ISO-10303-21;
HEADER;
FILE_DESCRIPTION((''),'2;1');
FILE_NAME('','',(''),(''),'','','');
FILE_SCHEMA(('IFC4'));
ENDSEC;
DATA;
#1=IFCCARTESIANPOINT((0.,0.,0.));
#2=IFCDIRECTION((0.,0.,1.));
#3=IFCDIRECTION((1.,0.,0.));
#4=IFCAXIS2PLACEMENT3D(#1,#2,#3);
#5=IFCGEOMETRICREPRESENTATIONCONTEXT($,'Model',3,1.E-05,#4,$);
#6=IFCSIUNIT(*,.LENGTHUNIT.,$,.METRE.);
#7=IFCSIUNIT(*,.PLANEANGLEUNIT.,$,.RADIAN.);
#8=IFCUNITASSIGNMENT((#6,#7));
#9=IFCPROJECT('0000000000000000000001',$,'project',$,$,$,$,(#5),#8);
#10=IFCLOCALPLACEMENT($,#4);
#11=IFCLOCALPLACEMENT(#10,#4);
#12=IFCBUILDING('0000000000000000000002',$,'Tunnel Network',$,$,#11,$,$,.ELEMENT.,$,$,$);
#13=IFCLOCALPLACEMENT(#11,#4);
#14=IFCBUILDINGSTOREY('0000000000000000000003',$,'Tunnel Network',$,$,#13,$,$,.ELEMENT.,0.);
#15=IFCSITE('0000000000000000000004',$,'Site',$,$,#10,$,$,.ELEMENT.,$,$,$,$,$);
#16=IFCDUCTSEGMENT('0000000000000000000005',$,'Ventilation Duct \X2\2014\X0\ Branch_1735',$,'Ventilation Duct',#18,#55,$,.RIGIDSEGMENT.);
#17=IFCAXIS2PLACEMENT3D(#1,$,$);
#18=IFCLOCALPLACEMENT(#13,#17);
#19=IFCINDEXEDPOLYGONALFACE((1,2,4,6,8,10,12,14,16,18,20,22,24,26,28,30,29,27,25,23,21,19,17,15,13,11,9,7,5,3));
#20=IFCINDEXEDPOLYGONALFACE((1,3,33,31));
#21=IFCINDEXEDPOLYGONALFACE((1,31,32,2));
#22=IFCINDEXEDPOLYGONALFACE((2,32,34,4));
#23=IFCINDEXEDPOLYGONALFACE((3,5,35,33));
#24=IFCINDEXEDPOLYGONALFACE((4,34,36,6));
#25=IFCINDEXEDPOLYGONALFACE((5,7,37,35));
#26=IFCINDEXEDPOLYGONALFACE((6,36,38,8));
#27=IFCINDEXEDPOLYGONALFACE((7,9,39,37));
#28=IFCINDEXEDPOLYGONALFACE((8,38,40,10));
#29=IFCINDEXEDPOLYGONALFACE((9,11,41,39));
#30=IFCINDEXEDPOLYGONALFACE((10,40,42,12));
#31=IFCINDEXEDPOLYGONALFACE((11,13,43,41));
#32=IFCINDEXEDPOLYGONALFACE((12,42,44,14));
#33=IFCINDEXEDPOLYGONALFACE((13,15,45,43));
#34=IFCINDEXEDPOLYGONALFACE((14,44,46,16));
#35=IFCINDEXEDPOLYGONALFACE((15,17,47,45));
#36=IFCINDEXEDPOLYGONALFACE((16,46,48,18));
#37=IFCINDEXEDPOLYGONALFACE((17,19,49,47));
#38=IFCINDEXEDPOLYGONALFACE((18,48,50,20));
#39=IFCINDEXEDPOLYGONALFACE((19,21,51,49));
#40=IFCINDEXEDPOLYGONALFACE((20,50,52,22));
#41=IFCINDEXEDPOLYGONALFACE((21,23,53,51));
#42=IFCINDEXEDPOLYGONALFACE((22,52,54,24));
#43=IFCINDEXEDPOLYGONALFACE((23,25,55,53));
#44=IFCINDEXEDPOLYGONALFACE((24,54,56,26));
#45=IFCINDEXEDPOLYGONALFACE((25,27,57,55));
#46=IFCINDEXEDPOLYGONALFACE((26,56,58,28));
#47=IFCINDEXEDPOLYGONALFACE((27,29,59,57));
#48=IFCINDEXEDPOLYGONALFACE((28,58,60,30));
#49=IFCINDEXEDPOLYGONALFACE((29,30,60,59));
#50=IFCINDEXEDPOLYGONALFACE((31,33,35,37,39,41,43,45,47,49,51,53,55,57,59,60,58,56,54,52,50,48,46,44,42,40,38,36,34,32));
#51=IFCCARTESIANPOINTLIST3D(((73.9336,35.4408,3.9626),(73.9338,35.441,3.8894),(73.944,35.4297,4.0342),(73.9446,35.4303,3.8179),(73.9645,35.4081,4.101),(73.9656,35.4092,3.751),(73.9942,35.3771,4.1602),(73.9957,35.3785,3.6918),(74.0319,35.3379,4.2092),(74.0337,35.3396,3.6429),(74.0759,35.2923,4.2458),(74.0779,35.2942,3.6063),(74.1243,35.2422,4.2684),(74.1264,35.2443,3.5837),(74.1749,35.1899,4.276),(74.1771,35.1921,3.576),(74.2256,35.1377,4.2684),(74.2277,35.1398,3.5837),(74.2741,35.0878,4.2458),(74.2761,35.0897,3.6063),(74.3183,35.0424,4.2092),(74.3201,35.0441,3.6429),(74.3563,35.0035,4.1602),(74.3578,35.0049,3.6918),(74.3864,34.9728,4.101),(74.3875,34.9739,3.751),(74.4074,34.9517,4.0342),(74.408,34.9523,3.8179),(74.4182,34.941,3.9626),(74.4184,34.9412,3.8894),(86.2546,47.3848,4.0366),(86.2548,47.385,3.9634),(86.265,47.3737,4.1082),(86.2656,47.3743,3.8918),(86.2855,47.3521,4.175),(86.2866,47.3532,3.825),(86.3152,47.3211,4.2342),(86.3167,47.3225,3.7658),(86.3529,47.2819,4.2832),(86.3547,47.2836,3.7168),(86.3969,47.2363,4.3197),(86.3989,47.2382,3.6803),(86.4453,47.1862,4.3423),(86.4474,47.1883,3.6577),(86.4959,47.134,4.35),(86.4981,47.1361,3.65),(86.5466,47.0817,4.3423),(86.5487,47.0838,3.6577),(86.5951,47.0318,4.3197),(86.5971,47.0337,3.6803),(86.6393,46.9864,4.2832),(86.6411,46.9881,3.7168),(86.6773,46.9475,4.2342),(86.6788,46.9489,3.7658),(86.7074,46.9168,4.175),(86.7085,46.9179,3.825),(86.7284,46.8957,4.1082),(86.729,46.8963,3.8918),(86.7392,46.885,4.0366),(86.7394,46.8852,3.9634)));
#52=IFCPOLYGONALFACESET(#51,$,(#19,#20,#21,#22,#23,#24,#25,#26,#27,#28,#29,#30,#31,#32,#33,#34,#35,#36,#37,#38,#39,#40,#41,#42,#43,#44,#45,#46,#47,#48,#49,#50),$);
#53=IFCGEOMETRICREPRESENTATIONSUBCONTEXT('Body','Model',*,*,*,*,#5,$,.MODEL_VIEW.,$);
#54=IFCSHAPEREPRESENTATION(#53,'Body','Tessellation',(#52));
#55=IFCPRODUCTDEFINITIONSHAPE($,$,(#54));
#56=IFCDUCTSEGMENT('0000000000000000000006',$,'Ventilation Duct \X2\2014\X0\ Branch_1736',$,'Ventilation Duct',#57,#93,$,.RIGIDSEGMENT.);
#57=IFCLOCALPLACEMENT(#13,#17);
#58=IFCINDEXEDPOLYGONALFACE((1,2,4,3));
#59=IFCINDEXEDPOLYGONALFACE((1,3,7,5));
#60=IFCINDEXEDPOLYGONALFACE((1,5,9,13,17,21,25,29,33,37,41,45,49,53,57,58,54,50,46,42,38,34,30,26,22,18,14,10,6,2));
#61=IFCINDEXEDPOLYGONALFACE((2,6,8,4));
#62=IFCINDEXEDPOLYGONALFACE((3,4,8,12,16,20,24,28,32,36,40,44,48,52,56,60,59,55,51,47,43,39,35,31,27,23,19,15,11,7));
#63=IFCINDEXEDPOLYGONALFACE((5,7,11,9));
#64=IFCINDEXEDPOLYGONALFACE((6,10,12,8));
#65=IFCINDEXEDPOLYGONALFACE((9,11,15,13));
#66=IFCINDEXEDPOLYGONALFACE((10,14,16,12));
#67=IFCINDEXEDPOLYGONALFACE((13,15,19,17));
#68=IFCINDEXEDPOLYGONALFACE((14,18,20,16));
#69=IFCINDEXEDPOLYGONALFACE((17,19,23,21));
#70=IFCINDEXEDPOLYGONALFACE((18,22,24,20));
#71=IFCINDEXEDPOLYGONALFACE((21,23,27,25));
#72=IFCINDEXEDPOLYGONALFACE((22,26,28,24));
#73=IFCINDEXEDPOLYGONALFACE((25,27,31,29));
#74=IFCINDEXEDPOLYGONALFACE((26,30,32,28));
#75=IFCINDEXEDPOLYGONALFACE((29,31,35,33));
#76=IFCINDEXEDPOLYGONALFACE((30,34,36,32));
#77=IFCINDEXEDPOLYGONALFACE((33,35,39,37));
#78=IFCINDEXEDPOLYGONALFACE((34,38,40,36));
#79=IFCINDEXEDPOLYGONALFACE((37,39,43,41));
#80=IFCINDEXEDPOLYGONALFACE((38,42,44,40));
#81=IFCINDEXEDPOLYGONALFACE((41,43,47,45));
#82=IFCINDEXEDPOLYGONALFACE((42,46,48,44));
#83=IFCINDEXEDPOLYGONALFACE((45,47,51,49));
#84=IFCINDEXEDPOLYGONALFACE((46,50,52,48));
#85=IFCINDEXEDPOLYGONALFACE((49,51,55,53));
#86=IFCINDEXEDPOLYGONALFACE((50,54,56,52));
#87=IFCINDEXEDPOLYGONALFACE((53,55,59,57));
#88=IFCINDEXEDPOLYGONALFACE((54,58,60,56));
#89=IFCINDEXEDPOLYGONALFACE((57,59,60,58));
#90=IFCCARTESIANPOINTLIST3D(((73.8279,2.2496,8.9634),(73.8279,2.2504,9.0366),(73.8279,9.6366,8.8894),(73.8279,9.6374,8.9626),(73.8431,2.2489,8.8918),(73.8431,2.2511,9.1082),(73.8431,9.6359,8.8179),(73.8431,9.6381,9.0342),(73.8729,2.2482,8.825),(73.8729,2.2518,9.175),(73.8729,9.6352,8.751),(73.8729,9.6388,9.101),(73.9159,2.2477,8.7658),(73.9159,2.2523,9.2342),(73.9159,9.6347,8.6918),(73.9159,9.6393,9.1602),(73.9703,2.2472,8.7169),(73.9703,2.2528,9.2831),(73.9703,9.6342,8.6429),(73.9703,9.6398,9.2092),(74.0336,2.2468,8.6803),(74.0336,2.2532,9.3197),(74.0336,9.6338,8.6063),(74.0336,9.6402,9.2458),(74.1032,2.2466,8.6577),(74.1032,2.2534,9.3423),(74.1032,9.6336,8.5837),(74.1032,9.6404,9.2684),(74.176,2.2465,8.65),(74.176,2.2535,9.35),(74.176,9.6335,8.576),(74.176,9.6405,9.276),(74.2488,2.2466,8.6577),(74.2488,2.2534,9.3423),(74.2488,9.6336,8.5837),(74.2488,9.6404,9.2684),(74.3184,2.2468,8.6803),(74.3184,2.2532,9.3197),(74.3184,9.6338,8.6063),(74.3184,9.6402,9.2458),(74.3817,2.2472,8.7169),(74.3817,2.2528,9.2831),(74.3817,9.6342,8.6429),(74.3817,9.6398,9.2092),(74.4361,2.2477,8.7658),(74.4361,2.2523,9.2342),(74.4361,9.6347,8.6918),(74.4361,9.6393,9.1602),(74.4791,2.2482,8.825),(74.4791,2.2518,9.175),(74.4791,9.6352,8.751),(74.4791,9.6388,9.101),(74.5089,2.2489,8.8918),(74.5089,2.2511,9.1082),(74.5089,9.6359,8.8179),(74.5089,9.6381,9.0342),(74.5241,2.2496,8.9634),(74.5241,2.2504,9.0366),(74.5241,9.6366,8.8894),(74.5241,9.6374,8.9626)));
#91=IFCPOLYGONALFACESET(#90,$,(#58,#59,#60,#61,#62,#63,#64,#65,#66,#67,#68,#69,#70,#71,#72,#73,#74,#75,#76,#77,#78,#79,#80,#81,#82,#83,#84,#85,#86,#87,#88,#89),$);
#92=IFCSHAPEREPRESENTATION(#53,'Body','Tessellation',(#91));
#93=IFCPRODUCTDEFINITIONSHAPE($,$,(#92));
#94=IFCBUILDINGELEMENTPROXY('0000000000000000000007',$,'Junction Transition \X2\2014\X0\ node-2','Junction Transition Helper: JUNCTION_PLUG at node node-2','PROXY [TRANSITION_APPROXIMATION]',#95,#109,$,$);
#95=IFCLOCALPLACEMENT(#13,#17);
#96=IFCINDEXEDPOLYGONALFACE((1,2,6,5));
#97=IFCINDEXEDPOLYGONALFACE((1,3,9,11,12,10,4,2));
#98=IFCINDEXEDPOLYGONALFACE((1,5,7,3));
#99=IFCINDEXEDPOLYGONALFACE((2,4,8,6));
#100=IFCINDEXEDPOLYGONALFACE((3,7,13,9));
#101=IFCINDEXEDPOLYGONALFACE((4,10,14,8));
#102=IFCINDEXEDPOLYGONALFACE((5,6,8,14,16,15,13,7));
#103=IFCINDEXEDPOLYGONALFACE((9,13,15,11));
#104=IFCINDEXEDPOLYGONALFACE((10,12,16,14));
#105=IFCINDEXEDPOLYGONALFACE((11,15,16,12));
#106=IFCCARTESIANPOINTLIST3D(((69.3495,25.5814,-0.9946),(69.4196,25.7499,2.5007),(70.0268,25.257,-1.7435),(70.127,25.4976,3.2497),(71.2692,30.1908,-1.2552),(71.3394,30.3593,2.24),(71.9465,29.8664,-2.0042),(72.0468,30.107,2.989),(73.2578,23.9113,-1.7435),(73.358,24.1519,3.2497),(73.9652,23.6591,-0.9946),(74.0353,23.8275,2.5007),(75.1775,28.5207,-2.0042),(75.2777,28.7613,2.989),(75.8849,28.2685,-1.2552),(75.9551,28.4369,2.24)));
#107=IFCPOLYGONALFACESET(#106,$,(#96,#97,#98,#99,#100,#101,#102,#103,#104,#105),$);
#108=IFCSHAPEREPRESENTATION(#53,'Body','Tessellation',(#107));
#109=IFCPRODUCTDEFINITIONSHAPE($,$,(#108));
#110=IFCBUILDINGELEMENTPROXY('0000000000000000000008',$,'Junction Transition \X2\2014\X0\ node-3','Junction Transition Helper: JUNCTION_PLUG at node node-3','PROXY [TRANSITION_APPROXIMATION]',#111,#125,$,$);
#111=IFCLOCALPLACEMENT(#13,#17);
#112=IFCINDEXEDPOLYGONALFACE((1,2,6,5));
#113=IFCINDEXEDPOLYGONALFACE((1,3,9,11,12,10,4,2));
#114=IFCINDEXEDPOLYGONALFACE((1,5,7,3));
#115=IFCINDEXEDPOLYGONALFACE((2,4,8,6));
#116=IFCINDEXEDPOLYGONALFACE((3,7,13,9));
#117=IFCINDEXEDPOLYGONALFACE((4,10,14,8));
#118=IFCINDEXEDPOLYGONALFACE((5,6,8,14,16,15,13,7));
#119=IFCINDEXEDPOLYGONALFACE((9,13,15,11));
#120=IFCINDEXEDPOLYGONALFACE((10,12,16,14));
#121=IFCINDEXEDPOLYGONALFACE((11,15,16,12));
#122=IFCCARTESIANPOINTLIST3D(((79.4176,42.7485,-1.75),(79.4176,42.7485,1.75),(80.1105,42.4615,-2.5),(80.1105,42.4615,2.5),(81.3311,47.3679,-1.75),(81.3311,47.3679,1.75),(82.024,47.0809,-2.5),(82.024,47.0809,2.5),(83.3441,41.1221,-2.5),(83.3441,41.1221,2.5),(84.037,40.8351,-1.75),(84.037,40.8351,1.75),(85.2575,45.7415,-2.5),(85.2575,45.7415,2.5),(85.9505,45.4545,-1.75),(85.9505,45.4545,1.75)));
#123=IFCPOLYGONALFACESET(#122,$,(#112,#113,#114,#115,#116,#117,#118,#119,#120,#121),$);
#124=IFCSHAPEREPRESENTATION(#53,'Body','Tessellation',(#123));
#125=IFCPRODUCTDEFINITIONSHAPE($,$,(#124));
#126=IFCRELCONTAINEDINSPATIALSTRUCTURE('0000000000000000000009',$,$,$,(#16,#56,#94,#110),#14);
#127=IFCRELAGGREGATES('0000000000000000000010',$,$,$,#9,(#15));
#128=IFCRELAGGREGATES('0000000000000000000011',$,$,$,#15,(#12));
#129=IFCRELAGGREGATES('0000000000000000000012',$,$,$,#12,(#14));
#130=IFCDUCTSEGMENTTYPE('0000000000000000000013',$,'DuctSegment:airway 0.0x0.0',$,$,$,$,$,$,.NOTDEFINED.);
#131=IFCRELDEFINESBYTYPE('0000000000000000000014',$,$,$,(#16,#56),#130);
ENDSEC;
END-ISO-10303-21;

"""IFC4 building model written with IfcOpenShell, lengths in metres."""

from ifc_helpers import new_model, si_unit, frame, origin_with_axes, origin_2d_with_axis, place, context, subcontext, project, spatial, polyline, circle, outline, extrude, type_object, element, save


model = new_model("IFC4")

# Units and contexts
model_context = context("Model", 3, precision=1e-05, world=origin_with_axes())
body_context = subcontext(model_context, "Body", "Model", "MODEL_VIEW")
ifc_project = project(units=[si_unit("LENGTHUNIT", "METRE"), si_unit("PLANEANGLEUNIT", "RADIAN")], contexts=[model_context])

# Site, building, storey
site_placement = place(None, origin_with_axes())
site = spatial("IfcSite", under=ifc_project, at=site_placement, Name="Site", CompositionType="ELEMENT")
building_placement = place(site_placement, origin_with_axes())
building = spatial("IfcBuilding", under=site, at=building_placement, Name="Tunnel Network", CompositionType="ELEMENT")
storey_placement = place(building_placement, origin_with_axes())
storey = spatial("IfcBuildingStorey", under=building, at=storey_placement, Name="Tunnel Network", CompositionType="ELEMENT", Elevation=0.0)

# Duct segments
duct_segment_type = type_object("IfcDuctSegmentType", Name="DuctSegment:airway 0.0x0.0")
duct_segment_1_placement = place(storey_placement, frame((74.176, 35.191, 3.926), z_axis=(0.718, 0.69603, 0.004311), x_axis=(-0.003095, -0.003, 0.999991)))
element("IfcDuctSegment", 1, at=duct_segment_1_placement, inside=storey, type_object=duct_segment_type, Name="Ventilation Duct — Branch_1735", ObjectType="Ventilation Duct", PredefinedType="RIGIDSEGMENT", context=body_context, shape_type="SweptSolid", body=[
    extrude(circle(Radius=0.35, at=origin_2d_with_axis()), origin_with_axes(), (0.0, 0.0, 1.0), 17.1602),
])
duct_segment_2_placement = place(storey_placement, frame((74.176, 2.25, 9.0), z_axis=(0.0, 0.99995, -0.010014), x_axis=(0.0, 0.010014, 0.99995)))
element("IfcDuctSegment", 2, at=duct_segment_2_placement, inside=storey, type_object=duct_segment_type, Name="Ventilation Duct — Branch_1736", ObjectType="Ventilation Duct", PredefinedType="RIGIDSEGMENT", context=body_context, shape_type="SweptSolid", body=[
    extrude(circle(Radius=0.35, at=origin_2d_with_axis()), origin_with_axes(), (0.0, 0.0, 1.0), 7.3874),
])

# Building element proxies
for number, where, z_axis, x_axis, name, description in (
    (3, (71.6924, 24.7045, 0.7531), (0.383949, 0.921882, -0.052133), (0.923137, -0.384471, 0.0), "Junction Transition — node-2", "Junction Transition Helper: JUNCTION_PLUG at node node-2"),
    (4, (81.7273, 41.7918, 0.0), (0.382683, 0.92388, 0.0), (0.92388, -0.382683, 0.0), "Junction Transition — node-3", "Junction Transition Helper: JUNCTION_PLUG at node node-3"),
):
    element("IfcBuildingElementProxy", number, at=place(storey_placement, frame(where, z_axis=z_axis, x_axis=x_axis)), inside=storey, Name=name, Description=description, ObjectType="PROXY [TRANSITION_APPROXIMATION]", context=body_context, shape_type="SweptSolid", body=[
        extrude(outline(polyline([(1.75, 2.5), (2.5, 1.75), (2.5, -1.75), (1.75, -2.5), (-1.75, -2.5), (-2.5, -1.75), (-2.5, 1.75), (-1.75, 2.5), (1.75, 2.5)])), origin_with_axes(), (0.0, 0.0, 1.0), 5.0),
    ])

save(model, "model.ifc")
